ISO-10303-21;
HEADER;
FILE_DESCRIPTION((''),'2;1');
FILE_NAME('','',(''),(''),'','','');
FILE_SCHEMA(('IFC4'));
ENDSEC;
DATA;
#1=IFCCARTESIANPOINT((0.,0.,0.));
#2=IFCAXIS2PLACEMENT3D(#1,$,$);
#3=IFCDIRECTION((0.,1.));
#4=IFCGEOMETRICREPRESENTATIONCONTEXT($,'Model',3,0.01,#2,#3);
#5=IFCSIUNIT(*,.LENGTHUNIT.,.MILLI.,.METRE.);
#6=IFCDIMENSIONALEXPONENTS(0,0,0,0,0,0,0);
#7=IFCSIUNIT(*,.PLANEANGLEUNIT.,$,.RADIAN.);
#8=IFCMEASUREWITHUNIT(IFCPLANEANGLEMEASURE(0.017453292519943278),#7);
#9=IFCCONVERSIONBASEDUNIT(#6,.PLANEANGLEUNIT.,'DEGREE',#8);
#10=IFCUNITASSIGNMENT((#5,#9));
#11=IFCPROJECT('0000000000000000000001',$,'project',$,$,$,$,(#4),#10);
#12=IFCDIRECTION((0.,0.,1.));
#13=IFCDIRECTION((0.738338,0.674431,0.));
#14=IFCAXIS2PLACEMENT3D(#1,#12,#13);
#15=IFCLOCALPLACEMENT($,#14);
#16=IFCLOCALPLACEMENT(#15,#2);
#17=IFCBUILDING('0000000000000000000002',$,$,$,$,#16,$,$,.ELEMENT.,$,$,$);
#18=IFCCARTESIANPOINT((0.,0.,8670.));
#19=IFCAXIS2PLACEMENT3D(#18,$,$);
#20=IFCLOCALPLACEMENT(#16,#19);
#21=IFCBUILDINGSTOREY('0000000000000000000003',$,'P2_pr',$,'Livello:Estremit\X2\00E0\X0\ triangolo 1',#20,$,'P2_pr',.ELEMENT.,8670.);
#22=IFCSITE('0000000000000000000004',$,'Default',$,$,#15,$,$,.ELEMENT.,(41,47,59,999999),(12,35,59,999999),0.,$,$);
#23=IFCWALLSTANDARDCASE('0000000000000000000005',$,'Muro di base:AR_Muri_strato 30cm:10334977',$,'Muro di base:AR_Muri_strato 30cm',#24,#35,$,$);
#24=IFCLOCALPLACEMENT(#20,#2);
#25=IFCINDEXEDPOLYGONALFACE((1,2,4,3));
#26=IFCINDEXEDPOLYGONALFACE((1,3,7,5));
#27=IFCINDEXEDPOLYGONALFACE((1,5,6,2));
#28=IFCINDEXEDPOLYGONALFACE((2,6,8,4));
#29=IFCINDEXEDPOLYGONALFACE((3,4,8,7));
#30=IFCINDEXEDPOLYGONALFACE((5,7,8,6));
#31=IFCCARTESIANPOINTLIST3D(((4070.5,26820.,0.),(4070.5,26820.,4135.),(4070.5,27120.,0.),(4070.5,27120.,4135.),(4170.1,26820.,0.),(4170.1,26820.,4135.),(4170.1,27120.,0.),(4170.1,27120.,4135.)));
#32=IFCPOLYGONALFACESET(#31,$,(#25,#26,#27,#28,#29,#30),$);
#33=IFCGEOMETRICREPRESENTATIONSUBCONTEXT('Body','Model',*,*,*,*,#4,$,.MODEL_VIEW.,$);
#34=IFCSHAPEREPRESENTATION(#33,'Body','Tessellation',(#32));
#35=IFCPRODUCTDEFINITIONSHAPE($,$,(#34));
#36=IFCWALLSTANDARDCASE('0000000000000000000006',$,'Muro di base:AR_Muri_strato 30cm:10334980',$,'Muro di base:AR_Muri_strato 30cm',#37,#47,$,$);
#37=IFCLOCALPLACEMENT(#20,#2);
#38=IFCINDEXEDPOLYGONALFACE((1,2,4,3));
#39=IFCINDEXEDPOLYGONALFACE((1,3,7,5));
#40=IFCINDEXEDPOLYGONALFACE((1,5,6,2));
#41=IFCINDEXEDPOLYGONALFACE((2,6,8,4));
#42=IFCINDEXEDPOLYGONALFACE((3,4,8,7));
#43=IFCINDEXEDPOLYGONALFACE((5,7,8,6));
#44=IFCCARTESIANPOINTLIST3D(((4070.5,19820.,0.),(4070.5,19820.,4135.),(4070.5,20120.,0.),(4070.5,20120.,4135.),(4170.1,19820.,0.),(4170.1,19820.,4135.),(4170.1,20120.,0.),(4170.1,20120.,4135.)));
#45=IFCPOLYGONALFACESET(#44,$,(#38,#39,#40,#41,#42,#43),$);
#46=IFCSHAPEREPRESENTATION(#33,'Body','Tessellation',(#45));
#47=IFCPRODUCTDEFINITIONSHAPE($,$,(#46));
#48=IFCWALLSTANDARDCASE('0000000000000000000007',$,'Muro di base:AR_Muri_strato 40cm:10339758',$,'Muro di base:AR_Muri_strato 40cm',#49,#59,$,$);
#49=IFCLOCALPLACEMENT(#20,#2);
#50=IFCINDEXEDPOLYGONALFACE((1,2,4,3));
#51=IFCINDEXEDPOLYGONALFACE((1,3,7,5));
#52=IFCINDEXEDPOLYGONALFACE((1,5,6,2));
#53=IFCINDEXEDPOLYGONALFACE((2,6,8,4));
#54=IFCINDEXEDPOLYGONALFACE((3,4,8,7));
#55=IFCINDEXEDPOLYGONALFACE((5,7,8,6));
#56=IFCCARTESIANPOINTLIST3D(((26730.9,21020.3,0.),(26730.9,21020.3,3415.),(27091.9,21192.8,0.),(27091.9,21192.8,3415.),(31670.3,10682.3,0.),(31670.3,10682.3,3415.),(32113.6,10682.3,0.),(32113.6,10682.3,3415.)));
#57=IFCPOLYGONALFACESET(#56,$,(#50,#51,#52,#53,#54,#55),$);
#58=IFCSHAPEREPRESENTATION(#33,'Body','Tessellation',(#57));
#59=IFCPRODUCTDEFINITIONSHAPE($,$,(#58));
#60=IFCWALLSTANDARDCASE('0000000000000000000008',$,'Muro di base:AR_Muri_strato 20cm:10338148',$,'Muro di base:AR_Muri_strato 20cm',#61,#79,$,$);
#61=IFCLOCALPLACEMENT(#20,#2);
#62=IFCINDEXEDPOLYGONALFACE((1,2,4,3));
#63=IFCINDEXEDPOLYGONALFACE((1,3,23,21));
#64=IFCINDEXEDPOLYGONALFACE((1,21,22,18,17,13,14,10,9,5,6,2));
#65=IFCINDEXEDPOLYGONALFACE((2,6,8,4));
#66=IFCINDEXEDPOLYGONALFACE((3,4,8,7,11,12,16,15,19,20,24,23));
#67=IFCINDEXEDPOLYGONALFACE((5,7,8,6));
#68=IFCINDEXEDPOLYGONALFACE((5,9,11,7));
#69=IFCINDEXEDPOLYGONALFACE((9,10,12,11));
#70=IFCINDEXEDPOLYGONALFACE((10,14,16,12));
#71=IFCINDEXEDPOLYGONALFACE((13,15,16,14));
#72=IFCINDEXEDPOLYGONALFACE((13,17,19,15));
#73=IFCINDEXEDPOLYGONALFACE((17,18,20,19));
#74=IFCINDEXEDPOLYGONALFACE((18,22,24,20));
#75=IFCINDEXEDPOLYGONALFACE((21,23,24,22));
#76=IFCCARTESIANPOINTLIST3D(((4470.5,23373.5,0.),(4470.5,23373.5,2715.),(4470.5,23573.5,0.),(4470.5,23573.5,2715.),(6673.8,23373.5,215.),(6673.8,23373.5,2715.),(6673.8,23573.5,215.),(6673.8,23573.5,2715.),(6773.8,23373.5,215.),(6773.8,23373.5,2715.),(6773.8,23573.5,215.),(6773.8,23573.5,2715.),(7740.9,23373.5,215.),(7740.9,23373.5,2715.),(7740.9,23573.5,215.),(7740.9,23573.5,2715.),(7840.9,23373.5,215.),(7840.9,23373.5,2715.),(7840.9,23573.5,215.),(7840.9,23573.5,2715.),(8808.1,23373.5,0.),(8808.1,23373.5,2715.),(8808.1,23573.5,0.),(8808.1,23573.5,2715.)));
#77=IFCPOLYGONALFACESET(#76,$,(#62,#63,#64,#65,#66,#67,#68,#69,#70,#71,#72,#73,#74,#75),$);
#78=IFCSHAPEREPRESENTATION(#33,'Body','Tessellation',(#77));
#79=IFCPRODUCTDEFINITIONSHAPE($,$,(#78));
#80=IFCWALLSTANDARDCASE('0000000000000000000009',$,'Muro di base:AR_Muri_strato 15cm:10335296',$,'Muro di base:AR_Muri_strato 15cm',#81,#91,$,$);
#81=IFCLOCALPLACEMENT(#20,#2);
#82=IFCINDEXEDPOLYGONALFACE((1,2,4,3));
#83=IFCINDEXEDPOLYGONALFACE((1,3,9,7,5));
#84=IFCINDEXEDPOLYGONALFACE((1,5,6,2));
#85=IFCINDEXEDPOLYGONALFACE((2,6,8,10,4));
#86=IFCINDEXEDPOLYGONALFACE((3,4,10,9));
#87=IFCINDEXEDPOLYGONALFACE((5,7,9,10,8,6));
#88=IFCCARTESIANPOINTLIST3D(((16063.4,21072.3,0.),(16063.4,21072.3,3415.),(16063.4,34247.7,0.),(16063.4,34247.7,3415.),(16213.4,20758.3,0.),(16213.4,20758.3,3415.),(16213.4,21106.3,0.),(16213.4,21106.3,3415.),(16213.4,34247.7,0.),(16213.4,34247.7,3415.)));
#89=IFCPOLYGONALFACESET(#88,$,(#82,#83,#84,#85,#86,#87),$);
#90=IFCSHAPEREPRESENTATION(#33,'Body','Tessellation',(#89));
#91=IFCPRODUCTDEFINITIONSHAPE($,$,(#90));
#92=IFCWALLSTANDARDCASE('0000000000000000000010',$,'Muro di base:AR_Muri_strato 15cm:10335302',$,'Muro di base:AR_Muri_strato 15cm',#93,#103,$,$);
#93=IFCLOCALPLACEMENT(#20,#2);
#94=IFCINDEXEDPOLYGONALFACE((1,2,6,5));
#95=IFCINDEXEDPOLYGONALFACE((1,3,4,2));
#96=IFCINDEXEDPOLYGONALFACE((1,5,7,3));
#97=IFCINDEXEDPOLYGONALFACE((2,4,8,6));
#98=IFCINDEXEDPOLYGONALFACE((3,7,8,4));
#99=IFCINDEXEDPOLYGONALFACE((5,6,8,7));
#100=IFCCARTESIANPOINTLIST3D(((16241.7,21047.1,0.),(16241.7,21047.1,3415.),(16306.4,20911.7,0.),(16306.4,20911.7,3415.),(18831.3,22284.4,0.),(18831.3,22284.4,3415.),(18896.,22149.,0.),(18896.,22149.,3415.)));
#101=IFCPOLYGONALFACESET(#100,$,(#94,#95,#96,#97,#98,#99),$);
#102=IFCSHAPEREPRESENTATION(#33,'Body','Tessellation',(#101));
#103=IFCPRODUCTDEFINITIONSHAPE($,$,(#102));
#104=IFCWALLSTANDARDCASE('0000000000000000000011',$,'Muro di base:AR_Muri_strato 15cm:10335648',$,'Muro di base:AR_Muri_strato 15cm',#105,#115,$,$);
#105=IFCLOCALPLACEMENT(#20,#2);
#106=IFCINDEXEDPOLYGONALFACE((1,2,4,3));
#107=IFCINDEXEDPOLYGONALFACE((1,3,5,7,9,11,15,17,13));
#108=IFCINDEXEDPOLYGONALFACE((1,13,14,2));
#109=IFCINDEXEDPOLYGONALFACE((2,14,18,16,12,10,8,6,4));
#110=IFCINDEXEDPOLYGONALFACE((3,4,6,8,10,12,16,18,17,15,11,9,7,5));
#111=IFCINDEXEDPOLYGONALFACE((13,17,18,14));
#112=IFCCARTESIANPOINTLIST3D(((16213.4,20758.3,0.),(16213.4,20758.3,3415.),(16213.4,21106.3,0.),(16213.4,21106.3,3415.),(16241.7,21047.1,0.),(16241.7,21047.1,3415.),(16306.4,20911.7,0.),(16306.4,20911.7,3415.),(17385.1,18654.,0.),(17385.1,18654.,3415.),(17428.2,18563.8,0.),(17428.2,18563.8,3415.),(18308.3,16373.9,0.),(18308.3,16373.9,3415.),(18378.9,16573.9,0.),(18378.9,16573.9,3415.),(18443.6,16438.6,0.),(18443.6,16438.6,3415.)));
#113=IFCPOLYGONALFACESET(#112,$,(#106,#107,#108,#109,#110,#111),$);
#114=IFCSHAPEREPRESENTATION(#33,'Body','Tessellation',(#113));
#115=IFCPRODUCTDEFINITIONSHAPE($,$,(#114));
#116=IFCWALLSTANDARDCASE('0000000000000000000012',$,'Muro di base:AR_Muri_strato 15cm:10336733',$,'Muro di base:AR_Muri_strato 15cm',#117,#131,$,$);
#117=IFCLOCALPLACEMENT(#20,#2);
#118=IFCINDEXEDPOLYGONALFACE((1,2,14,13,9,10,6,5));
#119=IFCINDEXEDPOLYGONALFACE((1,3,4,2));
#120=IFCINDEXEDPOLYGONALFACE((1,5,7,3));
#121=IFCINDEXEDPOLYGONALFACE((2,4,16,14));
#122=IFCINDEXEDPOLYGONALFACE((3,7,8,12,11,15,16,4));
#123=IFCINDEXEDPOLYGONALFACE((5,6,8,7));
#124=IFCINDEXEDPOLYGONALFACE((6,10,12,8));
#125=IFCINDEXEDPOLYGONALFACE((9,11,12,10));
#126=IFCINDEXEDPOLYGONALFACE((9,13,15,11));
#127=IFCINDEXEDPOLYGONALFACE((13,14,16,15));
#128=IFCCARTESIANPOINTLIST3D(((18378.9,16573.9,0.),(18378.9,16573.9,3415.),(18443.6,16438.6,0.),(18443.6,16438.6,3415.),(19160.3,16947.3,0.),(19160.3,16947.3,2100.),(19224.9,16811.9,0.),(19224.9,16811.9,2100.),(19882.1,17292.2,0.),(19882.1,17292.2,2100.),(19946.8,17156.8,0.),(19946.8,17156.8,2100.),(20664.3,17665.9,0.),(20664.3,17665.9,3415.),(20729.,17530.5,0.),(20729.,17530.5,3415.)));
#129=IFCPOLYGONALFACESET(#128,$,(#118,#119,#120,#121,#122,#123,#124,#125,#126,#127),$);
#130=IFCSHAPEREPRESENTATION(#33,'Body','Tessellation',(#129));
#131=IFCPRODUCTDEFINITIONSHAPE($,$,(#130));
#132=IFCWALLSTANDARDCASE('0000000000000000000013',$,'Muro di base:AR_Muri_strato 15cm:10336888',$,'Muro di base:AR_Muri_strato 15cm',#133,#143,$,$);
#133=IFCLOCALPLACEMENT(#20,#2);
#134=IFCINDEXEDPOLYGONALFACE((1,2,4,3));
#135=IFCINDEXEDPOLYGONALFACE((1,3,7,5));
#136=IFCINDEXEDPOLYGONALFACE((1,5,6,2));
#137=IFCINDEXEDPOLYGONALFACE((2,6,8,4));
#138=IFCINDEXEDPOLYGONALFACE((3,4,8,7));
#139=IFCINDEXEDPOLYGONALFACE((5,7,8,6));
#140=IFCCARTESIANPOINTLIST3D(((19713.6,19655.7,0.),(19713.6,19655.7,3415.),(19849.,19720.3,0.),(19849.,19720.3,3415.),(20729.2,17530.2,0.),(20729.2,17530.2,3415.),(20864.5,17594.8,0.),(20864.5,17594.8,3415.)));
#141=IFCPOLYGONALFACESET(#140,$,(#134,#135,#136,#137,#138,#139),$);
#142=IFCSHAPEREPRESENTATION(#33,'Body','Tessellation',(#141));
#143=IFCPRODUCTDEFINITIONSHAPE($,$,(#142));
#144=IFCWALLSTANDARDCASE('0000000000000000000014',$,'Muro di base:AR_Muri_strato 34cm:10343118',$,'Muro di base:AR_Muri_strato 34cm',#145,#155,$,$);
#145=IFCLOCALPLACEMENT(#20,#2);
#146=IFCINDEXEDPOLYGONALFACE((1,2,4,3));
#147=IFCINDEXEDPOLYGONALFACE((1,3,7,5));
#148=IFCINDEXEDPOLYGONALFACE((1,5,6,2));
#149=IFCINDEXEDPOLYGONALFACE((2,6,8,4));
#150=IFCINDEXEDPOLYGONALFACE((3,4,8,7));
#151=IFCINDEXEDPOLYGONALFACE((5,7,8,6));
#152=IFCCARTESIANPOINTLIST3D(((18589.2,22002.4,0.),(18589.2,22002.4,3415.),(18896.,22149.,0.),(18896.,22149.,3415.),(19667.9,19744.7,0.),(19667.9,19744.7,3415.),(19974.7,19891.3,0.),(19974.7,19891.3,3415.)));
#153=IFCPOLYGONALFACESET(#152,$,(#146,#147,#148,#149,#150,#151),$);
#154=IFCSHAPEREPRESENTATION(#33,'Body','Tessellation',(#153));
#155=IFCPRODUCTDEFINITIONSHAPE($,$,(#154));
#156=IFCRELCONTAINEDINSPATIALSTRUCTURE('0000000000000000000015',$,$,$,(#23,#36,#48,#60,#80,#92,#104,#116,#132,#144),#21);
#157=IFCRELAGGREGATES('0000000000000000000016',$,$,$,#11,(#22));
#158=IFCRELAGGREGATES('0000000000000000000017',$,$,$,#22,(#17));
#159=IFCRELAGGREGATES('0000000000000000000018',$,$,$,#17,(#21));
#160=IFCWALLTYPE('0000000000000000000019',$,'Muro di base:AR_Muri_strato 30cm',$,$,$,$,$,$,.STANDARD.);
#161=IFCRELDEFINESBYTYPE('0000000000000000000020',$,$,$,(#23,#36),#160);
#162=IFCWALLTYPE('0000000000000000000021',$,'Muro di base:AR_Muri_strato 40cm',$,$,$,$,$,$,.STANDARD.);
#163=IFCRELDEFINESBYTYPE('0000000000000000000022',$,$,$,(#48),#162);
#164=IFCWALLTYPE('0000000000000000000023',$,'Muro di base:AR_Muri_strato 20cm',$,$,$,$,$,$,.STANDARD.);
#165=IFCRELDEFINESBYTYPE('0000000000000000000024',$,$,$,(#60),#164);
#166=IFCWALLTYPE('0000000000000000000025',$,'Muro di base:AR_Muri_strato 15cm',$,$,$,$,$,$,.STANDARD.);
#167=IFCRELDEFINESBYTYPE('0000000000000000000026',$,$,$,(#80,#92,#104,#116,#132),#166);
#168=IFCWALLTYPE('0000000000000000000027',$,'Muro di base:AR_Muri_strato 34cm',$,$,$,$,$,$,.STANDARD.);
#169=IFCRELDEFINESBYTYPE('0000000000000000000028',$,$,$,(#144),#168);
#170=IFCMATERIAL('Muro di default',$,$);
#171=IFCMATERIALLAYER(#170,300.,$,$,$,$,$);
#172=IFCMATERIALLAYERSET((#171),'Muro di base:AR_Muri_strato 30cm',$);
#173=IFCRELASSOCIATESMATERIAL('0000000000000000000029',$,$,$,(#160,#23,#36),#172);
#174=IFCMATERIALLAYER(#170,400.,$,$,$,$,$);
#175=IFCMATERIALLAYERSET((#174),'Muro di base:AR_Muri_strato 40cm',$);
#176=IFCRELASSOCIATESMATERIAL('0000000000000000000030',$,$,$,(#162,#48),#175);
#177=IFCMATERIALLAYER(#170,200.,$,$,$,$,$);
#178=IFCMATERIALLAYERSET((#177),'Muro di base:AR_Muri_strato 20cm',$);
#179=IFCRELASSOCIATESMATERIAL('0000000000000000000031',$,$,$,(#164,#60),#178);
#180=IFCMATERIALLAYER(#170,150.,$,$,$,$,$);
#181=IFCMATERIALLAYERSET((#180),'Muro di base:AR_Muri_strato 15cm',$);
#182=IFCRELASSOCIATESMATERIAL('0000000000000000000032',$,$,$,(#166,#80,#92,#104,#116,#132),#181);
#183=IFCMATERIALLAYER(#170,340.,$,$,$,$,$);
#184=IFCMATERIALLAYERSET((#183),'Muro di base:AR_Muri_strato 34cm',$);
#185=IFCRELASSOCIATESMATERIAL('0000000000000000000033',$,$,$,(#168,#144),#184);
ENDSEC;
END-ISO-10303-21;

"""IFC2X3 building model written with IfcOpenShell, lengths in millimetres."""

from ifc_helpers import new_model, entity, si_unit, converted_unit, direction, frame, frame_2d, origin, place, context, subcontext, project, spatial, polyline, rectangle, outline, extrude, clip, bounded_halfspace, material, layer, layer_set, layer_usage, type_object, element, save


model = new_model("IFC2X3")

# Units and contexts
model_context = context("Model", 3, precision=0.01, world=origin(), true_north=direction((0.0, 1.0)))
body_context = subcontext(model_context, "Body", "Model", "MODEL_VIEW")
ifc_project = project(units=[si_unit("LENGTHUNIT", "METRE", prefix="MILLI"), converted_unit("PLANEANGLEUNIT", "DEGREE", entity("IfcPlaneAngleMeasure", 0.017453292519943278), si_unit("PLANEANGLEUNIT", "RADIAN"), dimensions=[0, 0, 0, 0, 0, 0, 0])], contexts=[model_context])

# Site, building, storey
site_placement = place(None, frame((0.0, 0.0, 0.0), z_axis=(0.0, 0.0, 1.0), x_axis=(0.738338, 0.674431, 0.0)))
site = spatial("IfcSite", under=ifc_project, at=site_placement, Name="Default", CompositionType="ELEMENT", RefLatitude=(41, 47, 59, 999999), RefLongitude=(12, 35, 59, 999999), RefElevation=0.0)
building_placement = place(site_placement, origin())
building = spatial("IfcBuilding", under=site, at=building_placement, CompositionType="ELEMENT")
storey_placement = place(building_placement, frame((0.0, 0.0, 8670.0)))
storey = spatial("IfcBuildingStorey", under=building, at=storey_placement, Name="P2_pr", ObjectType="Livello:Estremità triangolo 1", LongName="P2_pr", CompositionType="ELEMENT", Elevation=8670.0)

# Shared definitions
ifc_material = material(Name="Muro di default")

# Walls
ifc_layer_1 = layer(ifc_material, 300.0)
ifc_layer_set_1 = layer_set([ifc_layer_1], Name="Muro di base:AR_Muri_strato 30cm")
ifc_layer_usage_1 = layer_usage(ifc_layer_set_1, "AXIS2", "NEGATIVE", 150.0)
wall_type_1 = type_object("IfcWallType", Name="Muro di base:AR_Muri_strato 30cm", PredefinedType="STANDARD", material=ifc_layer_set_1)
wall_1_placement = place(storey_placement, frame((4170.1, 26970.0, 0.0), z_axis=(0.0, 0.0, 1.0), x_axis=(-1.0, 0.0, 0.0)))
element("IfcWallStandardCase", 1, at=wall_1_placement, inside=storey, type_object=wall_type_1, material=ifc_layer_usage_1, Name="Muro di base:AR_Muri_strato 30cm:10334977", ObjectType="Muro di base:AR_Muri_strato 30cm", context=body_context, shape_type="SweptSolid", body=[
    extrude(rectangle(XDim=99.6, YDim=300.0, at=frame_2d((49.8, 0.0), x_axis=(-1.0, 0.0))), origin(), (0.0, 0.0, 1.0), 4135.0),
])
ifc_layer_usage_2 = layer_usage(ifc_layer_set_1, "AXIS2", "NEGATIVE", 150.0)
wall_2_placement = place(storey_placement, frame((4170.1, 19970.0, 0.0), z_axis=(0.0, 0.0, 1.0), x_axis=(-1.0, 0.0, 0.0)))
element("IfcWallStandardCase", 2, at=wall_2_placement, inside=storey, type_object=wall_type_1, material=ifc_layer_usage_2, Name="Muro di base:AR_Muri_strato 30cm:10334980", ObjectType="Muro di base:AR_Muri_strato 30cm", context=body_context, shape_type="SweptSolid", body=[
    extrude(rectangle(XDim=99.6, YDim=300.0, at=frame_2d((49.8, 0.0), x_axis=(-1.0, 0.0))), origin(), (0.0, 0.0, 1.0), 4135.0),
])
ifc_layer_2 = layer(ifc_material, 400.0)
ifc_layer_set_2 = layer_set([ifc_layer_2], Name="Muro di base:AR_Muri_strato 40cm")
ifc_layer_usage_3 = layer_usage(ifc_layer_set_2, "AXIS2", "NEGATIVE", 200.0)
wall_type_2 = type_object("IfcWallType", Name="Muro di base:AR_Muri_strato 40cm", PredefinedType="STANDARD", material=ifc_layer_set_2)
wall_3_placement = place(storey_placement, frame((26911.4, 21106.6, 0.0), z_axis=(0.0, 0.0, 1.0), x_axis=(0.431105, -0.902302, 0.0)))
element("IfcWallStandardCase", 3, at=wall_3_placement, inside=storey, type_object=wall_type_2, material=ifc_layer_usage_3, Name="Muro di base:AR_Muri_strato 40cm:10339758", ObjectType="Muro di base:AR_Muri_strato 40cm", context=body_context, shape_type="SweptSolid", body=[
    extrude(outline(polyline([(11457.4, -200.0), (11648.6, 200.0), (0.0, 200.0), (0.0, -200.0), (11457.4, -200.0)])), origin(), (0.0, 0.0, 1.0), 3415.0),
])
ifc_layer_3 = layer(ifc_material, 200.0)
ifc_layer_set_3 = layer_set([ifc_layer_3], Name="Muro di base:AR_Muri_strato 20cm")
ifc_layer_usage_4 = layer_usage(ifc_layer_set_3, "AXIS2", "NEGATIVE", 100.0)
wall_type_3 = type_object("IfcWallType", Name="Muro di base:AR_Muri_strato 20cm", PredefinedType="STANDARD", material=ifc_layer_set_3)
wall_4_placement = place(storey_placement, frame((8808.1, 23473.5, 0.0), z_axis=(0.0, 0.0, 1.0), x_axis=(-1.0, 0.0, 0.0)))
element("IfcWallStandardCase", 4, at=wall_4_placement, inside=storey, type_object=wall_type_3, material=ifc_layer_usage_4, Name="Muro di base:AR_Muri_strato 20cm:10338148", ObjectType="Muro di base:AR_Muri_strato 20cm", context=body_context, shape_type="Clipping", body=[
    clip(clip(extrude(rectangle(XDim=4337.6, YDim=200.0, at=frame_2d((2168.8, 0.0), x_axis=(-1.0, 0.0))), origin(), (0.0, 0.0, 1.0), 2715.0), bounded_halfspace(frame((1067.1, -100.0, 215.0), z_axis=(0.0, 0.0, -1.0), x_axis=(-1.0, 0.0, 0.0)), True, frame((1067.1, -100.0, 215.0), z_axis=(0.0, 0.0, -1.0), x_axis=(-1.0, 0.0, 0.0)), polyline([(0.0, 0.0), (100.0, 0.0), (100.0, 200.0), (0.0, 200.0), (0.0, 0.0)]))), bounded_halfspace(frame((2134.2, -100.0, 215.0), z_axis=(0.0, 0.0, -1.0), x_axis=(-1.0, 0.0, 0.0)), True, frame((2134.2, -100.0, 215.0), z_axis=(0.0, 0.0, -1.0), x_axis=(-1.0, 0.0, 0.0)), polyline([(0.0, 0.0), (100.0, 0.0), (100.0, 200.0), (0.0, 200.0), (0.0, 0.0)]))),
])
ifc_layer_4 = layer(ifc_material, 150.0)
ifc_layer_set_4 = layer_set([ifc_layer_4], Name="Muro di base:AR_Muri_strato 15cm")
ifc_layer_usage_5 = layer_usage(ifc_layer_set_4, "AXIS2", "NEGATIVE", 75.0)
wall_type_4 = type_object("IfcWallType", Name="Muro di base:AR_Muri_strato 15cm", PredefinedType="STANDARD", material=ifc_layer_set_4)
wall_5_placement = place(storey_placement, frame((16138.4, 20758.3, 0.0), z_axis=(0.0, 0.0, 1.0), x_axis=(0.0, 1.0, 0.0)))
element("IfcWallStandardCase", 5, at=wall_5_placement, inside=storey, type_object=wall_type_4, material=ifc_layer_usage_5, Name="Muro di base:AR_Muri_strato 15cm:10335296", ObjectType="Muro di base:AR_Muri_strato 15cm", context=body_context, shape_type="SweptSolid", body=[
    extrude(outline(polyline([(13489.4, -75.0), (13489.4, 75.0), (313.9, 75.0), (0.0, -75.0), (347.9, -75.0), (13489.4, -75.0)])), origin(), (0.0, 0.0, 1.0), 3415.0),
])
ifc_layer_usage_6 = layer_usage(ifc_layer_set_4, "AXIS2", "NEGATIVE", 75.0)
wall_6_placement = place(storey_placement, frame((18863.7, 22216.7, 0.0), z_axis=(0.0, 0.0, 1.0), x_axis=(-0.9023, -0.431108, 0.0)))
element("IfcWallStandardCase", 6, at=wall_6_placement, inside=storey, type_object=wall_type_4, material=ifc_layer_usage_6, Name="Muro di base:AR_Muri_strato 15cm:10335302", ObjectType="Muro di base:AR_Muri_strato 15cm", context=body_context, shape_type="SweptSolid", body=[
    extrude(rectangle(XDim=2870.0, YDim=150.0, at=frame_2d((1435.0, 0.0), x_axis=(-1.0, 0.0))), origin(), (0.0, 0.0, 1.0), 3415.0),
])
ifc_layer_usage_7 = layer_usage(ifc_layer_set_4, "AXIS2", "NEGATIVE", 75.0)
wall_7_placement = place(storey_placement, frame((18375.9, 16406.3, 0.0), z_axis=(0.0, 0.0, 1.0), x_axis=(-0.431108, 0.9023, 0.0)))
element("IfcWallStandardCase", 7, at=wall_7_placement, inside=storey, type_object=wall_type_4, material=ifc_layer_usage_7, Name="Muro di base:AR_Muri_strato 15cm:10335648", ObjectType="Muro di base:AR_Muri_strato 15cm", context=body_context, shape_type="SweptSolid", body=[
    extrude(outline(polyline([(5173.1, -75.0), (4859.1, 75.0), (0.0, 75.0), (0.0, -75.0), (150.0, -75.0), (2355.3, -75.0), (2455.3, -75.0), (4957.5, -75.0), (5107.5, -75.0), (5173.1, -75.0)])), origin(), (0.0, 0.0, 1.0), 3415.0),
])

# Wall, opening
ifc_layer_usage_8 = layer_usage(ifc_layer_set_4, "AXIS2", "NEGATIVE", 75.0)
wall_8_placement = place(storey_placement, frame((20696.6, 17598.2, 0.0), z_axis=(0.0, 0.0, 1.0), x_axis=(-0.902296, -0.431118, 0.0)))
wall_8 = element("IfcWallStandardCase", 8, at=wall_8_placement, inside=storey, type_object=wall_type_4, material=ifc_layer_usage_8, Name="Muro di base:AR_Muri_strato 15cm:10336733", ObjectType="Muro di base:AR_Muri_strato 15cm", context=body_context, shape_type="SweptSolid", body=[
    extrude(rectangle(XDim=2532.8, YDim=150.0, at=frame_2d((1266.4, 0.0), x_axis=(-1.0, 0.0))), origin(), (0.0, 0.0, 1.0), 3415.0),
])
opening_1_placement = place(wall_8_placement, frame((26261.4, 6956.1, 0.0), z_axis=(0.0, 0.0, 1.0), x_axis=(-0.902296, 0.431118, 0.0)))
element("IfcOpeningElement", 9, at=opening_1_placement, cuts=wall_8, ObjectType="Opening", context=body_context, shape_type="SweptSolid", body=[
    extrude(rectangle(XDim=2100.0, YDim=800.0, at=frame_2d((0.0, 0.0), x_axis=(1.0, 0.0))), frame((18928.8, 18359.5, 1050.0), z_axis=(0.431118, -0.902296, 0.0), x_axis=(0.0, 0.0, -1.0)), (0.0, 0.0, 1.0), 3048.0),
])

# Walls
ifc_layer_usage_9 = layer_usage(ifc_layer_set_4, "AXIS2", "NEGATIVE", 75.0)
wall_9_placement = place(storey_placement, frame((19781.3, 19688.0, 0.0), z_axis=(0.0, 0.0, 1.0), x_axis=(0.431105, -0.902302, 0.0)))
element("IfcWallStandardCase", 10, at=wall_9_placement, inside=storey, type_object=wall_type_4, material=ifc_layer_usage_9, Name="Muro di base:AR_Muri_strato 15cm:10336888", ObjectType="Muro di base:AR_Muri_strato 15cm", context=body_context, shape_type="SweptSolid", body=[
    extrude(rectangle(XDim=2355.7, YDim=150.0, at=frame_2d((1177.8, 0.0), x_axis=(-1.0, 0.0))), origin(), (0.0, 0.0, 1.0), 3415.0),
])
ifc_layer_5 = layer(ifc_material, 340.0)
ifc_layer_set_5 = layer_set([ifc_layer_5], Name="Muro di base:AR_Muri_strato 34cm")
ifc_layer_usage_10 = layer_usage(ifc_layer_set_5, "AXIS2", "NEGATIVE", 170.0)
wall_type_5 = type_object("IfcWallType", Name="Muro di base:AR_Muri_strato 34cm", PredefinedType="STANDARD", material=ifc_layer_set_5)
wall_10_placement = place(storey_placement, frame((18742.6, 22075.7, 0.0), z_axis=(0.0, 0.0, 1.0), x_axis=(0.431105, -0.902302, 0.0)))
element("IfcWallStandardCase", 11, at=wall_10_placement, inside=storey, type_object=wall_type_5, material=ifc_layer_usage_10, Name="Muro di base:AR_Muri_strato 34cm:10343118", ObjectType="Muro di base:AR_Muri_strato 34cm", context=body_context, shape_type="SweptSolid", body=[
    extrude(rectangle(XDim=2502.2, YDim=340.0, at=frame_2d((1251.1, 0.0), x_axis=(-1.0, 0.0))), origin(), (0.0, 0.0, 1.0), 3415.0),
])

save(model, "model.ifc")
